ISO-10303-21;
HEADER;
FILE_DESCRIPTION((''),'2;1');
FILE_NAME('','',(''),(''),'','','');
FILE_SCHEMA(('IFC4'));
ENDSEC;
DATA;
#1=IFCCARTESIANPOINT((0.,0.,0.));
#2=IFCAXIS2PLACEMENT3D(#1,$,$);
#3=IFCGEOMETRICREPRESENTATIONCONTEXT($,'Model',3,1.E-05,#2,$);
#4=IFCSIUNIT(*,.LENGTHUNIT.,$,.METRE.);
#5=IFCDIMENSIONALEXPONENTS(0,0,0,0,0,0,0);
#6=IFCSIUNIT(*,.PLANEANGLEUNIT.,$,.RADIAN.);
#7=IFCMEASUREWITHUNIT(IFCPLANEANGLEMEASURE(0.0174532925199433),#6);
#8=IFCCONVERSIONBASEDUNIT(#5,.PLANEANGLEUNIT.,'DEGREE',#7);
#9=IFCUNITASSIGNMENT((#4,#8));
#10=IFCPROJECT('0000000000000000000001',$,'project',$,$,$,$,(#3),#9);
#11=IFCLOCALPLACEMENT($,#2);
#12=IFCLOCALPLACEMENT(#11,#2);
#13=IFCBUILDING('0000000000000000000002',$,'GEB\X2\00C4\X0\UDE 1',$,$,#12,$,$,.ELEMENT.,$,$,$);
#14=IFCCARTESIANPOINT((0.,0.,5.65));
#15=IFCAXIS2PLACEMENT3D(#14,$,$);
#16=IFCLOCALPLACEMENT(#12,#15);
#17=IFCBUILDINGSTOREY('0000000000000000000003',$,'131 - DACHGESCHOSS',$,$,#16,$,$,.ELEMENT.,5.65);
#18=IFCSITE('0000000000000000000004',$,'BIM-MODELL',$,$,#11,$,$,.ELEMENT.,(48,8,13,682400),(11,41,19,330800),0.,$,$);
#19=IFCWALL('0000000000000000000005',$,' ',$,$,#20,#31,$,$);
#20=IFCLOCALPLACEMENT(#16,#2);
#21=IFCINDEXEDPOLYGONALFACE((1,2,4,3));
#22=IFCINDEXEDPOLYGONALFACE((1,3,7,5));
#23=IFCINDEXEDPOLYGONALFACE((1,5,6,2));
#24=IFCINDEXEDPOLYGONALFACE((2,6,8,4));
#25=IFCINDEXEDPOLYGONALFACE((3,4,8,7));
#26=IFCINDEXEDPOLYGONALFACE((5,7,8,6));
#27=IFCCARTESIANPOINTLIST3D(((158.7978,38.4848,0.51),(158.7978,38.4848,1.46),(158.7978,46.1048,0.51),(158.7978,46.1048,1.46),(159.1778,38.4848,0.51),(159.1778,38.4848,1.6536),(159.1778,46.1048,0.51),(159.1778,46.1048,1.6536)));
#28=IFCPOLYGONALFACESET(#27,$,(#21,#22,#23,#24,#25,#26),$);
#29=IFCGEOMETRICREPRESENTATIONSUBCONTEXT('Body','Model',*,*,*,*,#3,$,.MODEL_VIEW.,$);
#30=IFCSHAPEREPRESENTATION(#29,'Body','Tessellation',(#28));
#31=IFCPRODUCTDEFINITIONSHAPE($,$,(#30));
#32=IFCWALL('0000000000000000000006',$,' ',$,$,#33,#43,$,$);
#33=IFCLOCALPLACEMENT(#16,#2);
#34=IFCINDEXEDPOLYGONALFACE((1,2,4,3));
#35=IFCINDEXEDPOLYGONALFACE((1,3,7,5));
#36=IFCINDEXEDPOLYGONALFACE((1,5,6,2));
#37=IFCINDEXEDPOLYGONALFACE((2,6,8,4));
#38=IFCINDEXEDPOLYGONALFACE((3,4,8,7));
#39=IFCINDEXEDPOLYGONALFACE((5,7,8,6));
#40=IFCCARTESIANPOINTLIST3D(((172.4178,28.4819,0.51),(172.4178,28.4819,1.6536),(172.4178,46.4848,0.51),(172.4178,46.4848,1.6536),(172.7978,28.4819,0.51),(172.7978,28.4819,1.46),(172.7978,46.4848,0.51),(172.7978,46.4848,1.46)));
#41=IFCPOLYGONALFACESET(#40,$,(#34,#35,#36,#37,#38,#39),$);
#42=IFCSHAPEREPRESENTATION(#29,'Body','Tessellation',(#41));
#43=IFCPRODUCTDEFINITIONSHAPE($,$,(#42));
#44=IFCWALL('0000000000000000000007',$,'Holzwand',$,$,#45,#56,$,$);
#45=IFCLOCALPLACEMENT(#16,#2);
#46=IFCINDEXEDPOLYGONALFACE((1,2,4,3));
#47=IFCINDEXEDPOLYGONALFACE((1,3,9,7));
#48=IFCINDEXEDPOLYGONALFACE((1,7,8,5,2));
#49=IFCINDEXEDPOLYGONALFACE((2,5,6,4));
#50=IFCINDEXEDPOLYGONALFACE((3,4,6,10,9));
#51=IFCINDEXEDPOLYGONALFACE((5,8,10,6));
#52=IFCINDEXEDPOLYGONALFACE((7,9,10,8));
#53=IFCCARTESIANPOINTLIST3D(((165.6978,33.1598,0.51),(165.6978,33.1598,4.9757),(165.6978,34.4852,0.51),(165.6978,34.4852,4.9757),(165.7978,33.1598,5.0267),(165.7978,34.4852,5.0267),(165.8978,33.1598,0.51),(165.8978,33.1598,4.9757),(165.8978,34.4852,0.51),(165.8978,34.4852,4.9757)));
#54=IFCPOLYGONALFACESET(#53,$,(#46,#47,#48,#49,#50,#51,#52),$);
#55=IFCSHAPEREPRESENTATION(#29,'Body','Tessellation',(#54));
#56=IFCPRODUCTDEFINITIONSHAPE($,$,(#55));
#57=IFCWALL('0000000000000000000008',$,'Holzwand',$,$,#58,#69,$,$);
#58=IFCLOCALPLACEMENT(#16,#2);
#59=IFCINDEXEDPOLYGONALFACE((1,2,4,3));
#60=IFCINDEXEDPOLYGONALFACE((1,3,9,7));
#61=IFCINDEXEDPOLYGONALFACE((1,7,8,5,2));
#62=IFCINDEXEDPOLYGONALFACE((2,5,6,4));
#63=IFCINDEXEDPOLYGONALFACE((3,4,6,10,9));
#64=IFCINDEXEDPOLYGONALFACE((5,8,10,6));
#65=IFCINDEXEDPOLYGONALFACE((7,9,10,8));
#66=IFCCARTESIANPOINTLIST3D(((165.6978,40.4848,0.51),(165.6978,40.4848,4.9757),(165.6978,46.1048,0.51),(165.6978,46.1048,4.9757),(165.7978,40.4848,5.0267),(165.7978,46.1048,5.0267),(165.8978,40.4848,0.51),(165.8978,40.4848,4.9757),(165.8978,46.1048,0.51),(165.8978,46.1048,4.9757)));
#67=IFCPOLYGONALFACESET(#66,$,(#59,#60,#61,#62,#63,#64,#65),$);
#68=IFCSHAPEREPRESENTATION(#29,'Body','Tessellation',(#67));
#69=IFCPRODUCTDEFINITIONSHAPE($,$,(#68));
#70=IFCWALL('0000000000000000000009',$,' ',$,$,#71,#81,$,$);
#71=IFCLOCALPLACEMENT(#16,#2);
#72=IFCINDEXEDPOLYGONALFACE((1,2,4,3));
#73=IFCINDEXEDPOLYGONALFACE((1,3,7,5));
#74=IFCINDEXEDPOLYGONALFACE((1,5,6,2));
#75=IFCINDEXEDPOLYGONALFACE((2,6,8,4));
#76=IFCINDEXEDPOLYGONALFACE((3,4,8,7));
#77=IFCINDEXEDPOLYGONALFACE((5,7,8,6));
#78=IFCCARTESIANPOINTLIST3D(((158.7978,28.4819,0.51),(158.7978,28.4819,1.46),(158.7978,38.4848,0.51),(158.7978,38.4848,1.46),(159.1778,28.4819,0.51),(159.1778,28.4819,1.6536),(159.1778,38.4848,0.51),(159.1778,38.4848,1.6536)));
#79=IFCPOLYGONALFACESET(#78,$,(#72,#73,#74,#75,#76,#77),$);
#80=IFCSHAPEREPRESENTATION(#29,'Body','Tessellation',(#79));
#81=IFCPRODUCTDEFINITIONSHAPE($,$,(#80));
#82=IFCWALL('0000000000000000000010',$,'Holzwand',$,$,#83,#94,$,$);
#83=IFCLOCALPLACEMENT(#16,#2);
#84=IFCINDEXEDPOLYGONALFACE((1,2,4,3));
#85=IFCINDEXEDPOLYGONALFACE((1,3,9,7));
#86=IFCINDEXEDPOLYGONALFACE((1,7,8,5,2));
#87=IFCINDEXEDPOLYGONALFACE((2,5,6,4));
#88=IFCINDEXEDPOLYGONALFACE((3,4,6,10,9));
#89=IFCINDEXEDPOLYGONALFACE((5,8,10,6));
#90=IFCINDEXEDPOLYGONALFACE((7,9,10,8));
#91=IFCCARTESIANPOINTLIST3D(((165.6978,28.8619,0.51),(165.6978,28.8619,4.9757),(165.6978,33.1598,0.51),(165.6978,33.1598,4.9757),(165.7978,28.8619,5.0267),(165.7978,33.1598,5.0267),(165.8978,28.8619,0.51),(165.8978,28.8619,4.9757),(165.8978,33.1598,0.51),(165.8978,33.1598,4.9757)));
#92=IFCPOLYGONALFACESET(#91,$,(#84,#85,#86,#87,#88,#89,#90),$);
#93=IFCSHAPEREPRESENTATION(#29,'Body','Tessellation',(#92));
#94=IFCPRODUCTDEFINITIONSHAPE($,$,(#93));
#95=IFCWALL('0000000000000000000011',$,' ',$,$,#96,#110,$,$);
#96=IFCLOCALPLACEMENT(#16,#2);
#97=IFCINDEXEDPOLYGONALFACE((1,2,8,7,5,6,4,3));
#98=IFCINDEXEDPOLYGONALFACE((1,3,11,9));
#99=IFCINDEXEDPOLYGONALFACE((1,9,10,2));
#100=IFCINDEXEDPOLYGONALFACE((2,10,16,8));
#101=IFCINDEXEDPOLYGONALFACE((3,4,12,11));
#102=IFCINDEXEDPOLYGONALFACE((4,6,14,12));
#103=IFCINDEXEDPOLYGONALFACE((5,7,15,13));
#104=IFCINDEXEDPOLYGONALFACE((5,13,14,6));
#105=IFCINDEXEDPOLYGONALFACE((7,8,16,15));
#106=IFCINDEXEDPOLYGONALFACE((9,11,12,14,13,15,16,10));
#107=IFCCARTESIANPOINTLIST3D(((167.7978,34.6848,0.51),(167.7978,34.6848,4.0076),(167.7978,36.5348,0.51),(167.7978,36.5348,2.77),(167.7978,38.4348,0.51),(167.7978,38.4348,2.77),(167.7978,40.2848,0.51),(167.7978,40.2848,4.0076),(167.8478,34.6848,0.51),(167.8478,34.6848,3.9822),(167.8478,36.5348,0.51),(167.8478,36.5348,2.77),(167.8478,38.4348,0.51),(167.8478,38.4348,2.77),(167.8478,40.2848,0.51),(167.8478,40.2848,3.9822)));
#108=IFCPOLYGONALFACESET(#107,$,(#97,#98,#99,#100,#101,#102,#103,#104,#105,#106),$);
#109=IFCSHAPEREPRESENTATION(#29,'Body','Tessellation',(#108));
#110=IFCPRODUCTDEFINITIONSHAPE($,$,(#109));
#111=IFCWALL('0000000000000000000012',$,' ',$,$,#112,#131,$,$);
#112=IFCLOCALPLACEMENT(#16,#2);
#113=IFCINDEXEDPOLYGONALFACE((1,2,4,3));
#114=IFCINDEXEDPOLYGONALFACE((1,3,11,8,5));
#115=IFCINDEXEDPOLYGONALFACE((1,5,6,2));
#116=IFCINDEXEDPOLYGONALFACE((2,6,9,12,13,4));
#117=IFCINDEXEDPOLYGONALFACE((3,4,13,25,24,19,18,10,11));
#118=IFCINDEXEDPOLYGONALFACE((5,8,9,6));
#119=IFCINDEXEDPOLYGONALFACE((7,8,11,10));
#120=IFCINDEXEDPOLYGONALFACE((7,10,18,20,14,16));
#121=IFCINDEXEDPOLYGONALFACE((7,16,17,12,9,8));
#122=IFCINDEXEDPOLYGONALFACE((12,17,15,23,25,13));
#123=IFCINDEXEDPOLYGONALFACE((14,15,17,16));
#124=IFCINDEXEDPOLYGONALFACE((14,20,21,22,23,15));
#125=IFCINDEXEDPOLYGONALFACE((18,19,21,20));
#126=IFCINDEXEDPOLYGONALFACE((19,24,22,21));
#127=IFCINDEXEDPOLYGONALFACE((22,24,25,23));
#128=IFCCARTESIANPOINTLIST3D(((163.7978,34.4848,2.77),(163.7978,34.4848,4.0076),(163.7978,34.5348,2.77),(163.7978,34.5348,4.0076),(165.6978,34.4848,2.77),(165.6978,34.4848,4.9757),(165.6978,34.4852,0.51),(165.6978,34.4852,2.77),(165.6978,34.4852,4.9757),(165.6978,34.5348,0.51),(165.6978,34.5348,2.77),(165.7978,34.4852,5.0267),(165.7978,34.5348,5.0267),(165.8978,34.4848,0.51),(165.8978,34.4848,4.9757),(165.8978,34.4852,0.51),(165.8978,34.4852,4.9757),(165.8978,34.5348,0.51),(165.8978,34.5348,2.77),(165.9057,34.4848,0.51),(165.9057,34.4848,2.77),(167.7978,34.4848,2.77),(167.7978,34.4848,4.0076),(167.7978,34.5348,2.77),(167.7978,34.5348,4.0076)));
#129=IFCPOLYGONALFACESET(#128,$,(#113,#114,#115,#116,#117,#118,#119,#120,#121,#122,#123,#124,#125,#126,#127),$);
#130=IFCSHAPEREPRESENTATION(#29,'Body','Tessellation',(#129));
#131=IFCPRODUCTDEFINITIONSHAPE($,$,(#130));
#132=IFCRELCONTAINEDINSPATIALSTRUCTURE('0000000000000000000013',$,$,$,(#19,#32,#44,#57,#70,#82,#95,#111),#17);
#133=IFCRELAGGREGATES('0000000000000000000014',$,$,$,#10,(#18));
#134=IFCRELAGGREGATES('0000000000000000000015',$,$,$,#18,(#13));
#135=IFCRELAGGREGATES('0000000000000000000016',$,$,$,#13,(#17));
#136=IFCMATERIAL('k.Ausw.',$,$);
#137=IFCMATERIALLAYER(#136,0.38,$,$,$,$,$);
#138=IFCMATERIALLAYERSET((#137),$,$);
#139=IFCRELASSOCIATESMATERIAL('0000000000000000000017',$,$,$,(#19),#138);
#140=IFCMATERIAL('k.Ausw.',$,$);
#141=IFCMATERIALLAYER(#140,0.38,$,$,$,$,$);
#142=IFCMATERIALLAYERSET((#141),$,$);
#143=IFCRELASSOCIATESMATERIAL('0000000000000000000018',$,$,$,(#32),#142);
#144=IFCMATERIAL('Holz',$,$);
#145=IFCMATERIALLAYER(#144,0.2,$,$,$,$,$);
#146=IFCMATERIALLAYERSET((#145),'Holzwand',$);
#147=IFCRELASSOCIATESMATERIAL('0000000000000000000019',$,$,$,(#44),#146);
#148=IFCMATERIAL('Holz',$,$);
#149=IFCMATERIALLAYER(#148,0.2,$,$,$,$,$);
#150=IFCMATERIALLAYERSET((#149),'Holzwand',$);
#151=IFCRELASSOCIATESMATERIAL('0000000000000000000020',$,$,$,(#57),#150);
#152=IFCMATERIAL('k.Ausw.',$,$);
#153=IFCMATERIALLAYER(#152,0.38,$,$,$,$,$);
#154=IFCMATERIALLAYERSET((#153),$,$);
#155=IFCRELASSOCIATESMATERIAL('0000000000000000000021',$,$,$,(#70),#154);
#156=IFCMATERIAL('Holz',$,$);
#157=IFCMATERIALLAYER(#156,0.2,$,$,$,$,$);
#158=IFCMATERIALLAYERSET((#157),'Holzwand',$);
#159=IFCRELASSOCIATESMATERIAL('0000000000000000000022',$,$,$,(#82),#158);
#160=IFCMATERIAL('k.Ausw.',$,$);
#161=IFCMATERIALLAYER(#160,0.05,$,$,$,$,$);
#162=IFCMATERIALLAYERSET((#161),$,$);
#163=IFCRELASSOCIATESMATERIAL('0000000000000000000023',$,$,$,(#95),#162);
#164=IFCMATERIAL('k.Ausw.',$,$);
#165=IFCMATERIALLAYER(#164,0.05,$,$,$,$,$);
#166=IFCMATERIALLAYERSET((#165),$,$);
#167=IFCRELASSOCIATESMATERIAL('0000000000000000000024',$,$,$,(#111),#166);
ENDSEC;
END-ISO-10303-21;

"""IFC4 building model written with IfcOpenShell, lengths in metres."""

from ifc_helpers import new_model, entity, si_unit, converted_unit, frame, frame_2d, origin, origin_with_axes, place, context, subcontext, project, spatial, polyline, rectangle, outline, extrude, clip, halfspace, bounded_halfspace, material, layer, layer_set, layer_usage, element, save


model = new_model("IFC4")

# Units and contexts
model_context = context("Model", 3, precision=1e-05, world=origin())
body_context = subcontext(model_context, "Body", "Model", "MODEL_VIEW")
ifc_project = project(units=[si_unit("LENGTHUNIT", "METRE"), converted_unit("PLANEANGLEUNIT", "DEGREE", entity("IfcPlaneAngleMeasure", 0.0174532925199433), si_unit("PLANEANGLEUNIT", "RADIAN"), dimensions=[0, 0, 0, 0, 0, 0, 0])], contexts=[model_context])

# Site, building, storey
site_placement = place(None, origin())
site = spatial("IfcSite", under=ifc_project, at=site_placement, Name="BIM-MODELL", CompositionType="ELEMENT", RefLatitude=(48, 8, 13, 682400), RefLongitude=(11, 41, 19, 330800), RefElevation=0.0)
building_placement = place(site_placement, origin())
building = spatial("IfcBuilding", under=site, at=building_placement, Name="GEBÄUDE 1", CompositionType="ELEMENT")
storey_placement = place(building_placement, frame((0.0, 0.0, 5.65)))
storey = spatial("IfcBuildingStorey", under=building, at=storey_placement, Name="131 - DACHGESCHOSS", CompositionType="ELEMENT", Elevation=5.65)

# Walls
ifc_material_1 = material(Name="k.Ausw.")
ifc_layer_1 = layer(ifc_material_1, 0.38)
ifc_layer_set_1 = layer_set([ifc_layer_1])
ifc_layer_usage_1 = layer_usage(ifc_layer_set_1, "AXIS2", "POSITIVE", 0.0)
wall_1_placement = place(storey_placement, frame((158.7978, 46.1048, 0.51), z_axis=(0.0, 0.0, 1.0), x_axis=(0.0, -1.0, 0.0)))
element("IfcWall", 1, at=wall_1_placement, inside=storey, material=ifc_layer_usage_1, Name=" ", context=body_context, shape_type="Clipping", body=[
    clip(extrude(rectangle(XDim=7.62, YDim=0.38, at=frame_2d((3.81, 0.19), x_axis=(1.0, 0.0))), origin_with_axes(), (0.0, 0.0, 1.0), 1.1436), halfspace(frame((3.81, 0.19, 1.0468), z_axis=(0.0, 0.45399, -0.891007), x_axis=(0.0, -0.891007, -0.45399)), True)),
])
ifc_material_2 = material(Name="k.Ausw.")
ifc_layer_2 = layer(ifc_material_2, 0.38)
ifc_layer_set_2 = layer_set([ifc_layer_2])
ifc_layer_usage_2 = layer_usage(ifc_layer_set_2, "AXIS2", "POSITIVE", 0.0)
wall_2_placement = place(storey_placement, frame((172.7978, 28.4819, 0.51), z_axis=(0.0, 0.0, 1.0), x_axis=(0.0, 1.0, 0.0)))
element("IfcWall", 2, at=wall_2_placement, inside=storey, material=ifc_layer_usage_2, Name=" ", context=body_context, shape_type="Clipping", body=[
    clip(extrude(rectangle(XDim=18.0029, YDim=0.38, at=frame_2d((9.0014, 0.19), x_axis=(1.0, 0.0))), origin_with_axes(), (0.0, 0.0, 1.0), 1.1436), halfspace(frame((9.0014, 0.19, 1.0468), z_axis=(0.0, 0.45399, -0.891007), x_axis=(0.0, -0.891007, -0.45399)), True)),
])
ifc_material_3 = material(Name="Holz")
ifc_layer_3 = layer(ifc_material_3, 0.2)
ifc_layer_set_3 = layer_set([ifc_layer_3], Name="Holzwand")
ifc_layer_usage_3 = layer_usage(ifc_layer_set_3, "AXIS2", "POSITIVE", 0.0)
wall_3_placement = place(storey_placement, frame((165.6978, 34.4852, 0.51), z_axis=(0.0, 0.0, 1.0), x_axis=(0.0, -1.0, 0.0)))
element("IfcWall", 3, at=wall_3_placement, inside=storey, material=ifc_layer_usage_3, Name="Holzwand", context=body_context, shape_type="Clipping", body=[
    clip(clip(extrude(rectangle(XDim=1.3254, YDim=0.2, at=frame_2d((0.6627, 0.1), x_axis=(1.0, 0.0))), origin_with_axes(), (0.0, 0.0, 1.0), 4.5167), bounded_halfspace(frame((0.6627, 0.15, 4.4912), z_axis=(0.0, -0.45399, -0.891007), x_axis=(0.0, -0.891007, 0.45399)), True, origin_with_axes(), polyline([(0.0, 0.2), (0.0, 0.1), (1.3254, 0.1), (1.3254, 0.2), (0.0, 0.2)]))), bounded_halfspace(frame((0.6627, 0.05, 4.4912), z_axis=(0.0, 0.45399, -0.891007), x_axis=(1.0, 0.0, 0.0)), True, origin_with_axes(), polyline([(0.0, 0.0), (1.3254, 0.0), (1.3254, 0.1), (0.0, 0.1), (0.0, 0.0)]))),
])
ifc_material_4 = material(Name="Holz")
ifc_layer_4 = layer(ifc_material_4, 0.2)
ifc_layer_set_4 = layer_set([ifc_layer_4], Name="Holzwand")
ifc_layer_usage_4 = layer_usage(ifc_layer_set_4, "AXIS2", "POSITIVE", 0.0)
wall_4_placement = place(storey_placement, frame((165.6978, 46.1048, 0.51), z_axis=(0.0, 0.0, 1.0), x_axis=(0.0, -1.0, 0.0)))
element("IfcWall", 4, at=wall_4_placement, inside=storey, material=ifc_layer_usage_4, Name="Holzwand", context=body_context, shape_type="Clipping", body=[
    clip(clip(extrude(rectangle(XDim=5.62, YDim=0.2, at=frame_2d((2.81, 0.1), x_axis=(1.0, 0.0))), origin_with_axes(), (0.0, 0.0, 1.0), 4.5167), bounded_halfspace(frame((2.81, 0.15, 4.4912), z_axis=(0.0, -0.45399, -0.891007), x_axis=(0.0, -0.891007, 0.45399)), True, origin_with_axes(), polyline([(0.0, 0.2), (0.0, 0.1), (5.62, 0.1), (5.62, 0.2), (0.0, 0.2)]))), bounded_halfspace(frame((2.81, 0.05, 4.4912), z_axis=(0.0, 0.45399, -0.891007), x_axis=(1.0, 0.0, 0.0)), True, origin_with_axes(), polyline([(0.0, 0.0), (5.62, 0.0), (5.62, 0.1), (0.0, 0.1), (0.0, 0.0)]))),
])
ifc_material_5 = material(Name="k.Ausw.")
ifc_layer_5 = layer(ifc_material_5, 0.38)
ifc_layer_set_5 = layer_set([ifc_layer_5])
ifc_layer_usage_5 = layer_usage(ifc_layer_set_5, "AXIS2", "POSITIVE", 0.0)
wall_5_placement = place(storey_placement, frame((158.7978, 38.4848, 0.51), z_axis=(0.0, 0.0, 1.0), x_axis=(0.0, -1.0, 0.0)))
element("IfcWall", 5, at=wall_5_placement, inside=storey, material=ifc_layer_usage_5, Name=" ", context=body_context, shape_type="Clipping", body=[
    clip(extrude(rectangle(XDim=10.0029, YDim=0.38, at=frame_2d((5.0014, 0.19), x_axis=(1.0, 0.0))), origin_with_axes(), (0.0, 0.0, 1.0), 1.1436), halfspace(frame((5.0014, 0.19, 1.0468), z_axis=(0.0, 0.45399, -0.891007), x_axis=(0.0, -0.891007, -0.45399)), True)),
])
ifc_material_6 = material(Name="Holz")
ifc_layer_6 = layer(ifc_material_6, 0.2)
ifc_layer_set_6 = layer_set([ifc_layer_6], Name="Holzwand")
ifc_layer_usage_6 = layer_usage(ifc_layer_set_6, "AXIS2", "POSITIVE", 0.0)
wall_6_placement = place(storey_placement, frame((165.6978, 33.1598, 0.51), z_axis=(0.0, 0.0, 1.0), x_axis=(0.0, -1.0, 0.0)))
element("IfcWall", 6, at=wall_6_placement, inside=storey, material=ifc_layer_usage_6, Name="Holzwand", context=body_context, shape_type="Clipping", body=[
    clip(clip(extrude(rectangle(XDim=4.2979, YDim=0.2, at=frame_2d((2.1489, 0.1), x_axis=(1.0, 0.0))), origin_with_axes(), (0.0, 0.0, 1.0), 4.5167), bounded_halfspace(frame((2.1489, 0.15, 4.4912), z_axis=(0.0, -0.45399, -0.891007), x_axis=(0.0, -0.891007, 0.45399)), True, origin_with_axes(), polyline([(0.0, 0.2), (0.0, 0.1), (4.2979, 0.1), (4.2979, 0.2), (0.0, 0.2)]))), bounded_halfspace(frame((2.1489, 0.05, 4.4912), z_axis=(0.0, 0.45399, -0.891007), x_axis=(1.0, 0.0, 0.0)), True, origin_with_axes(), polyline([(0.0, 0.0), (4.2979, 0.0), (4.2979, 0.1), (0.0, 0.1), (0.0, 0.0)]))),
])

# Wall, opening
ifc_material_7 = material(Name="k.Ausw.")
ifc_layer_7 = layer(ifc_material_7, 0.05)
ifc_layer_set_7 = layer_set([ifc_layer_7])
ifc_layer_usage_7 = layer_usage(ifc_layer_set_7, "AXIS2", "POSITIVE", 0.0)
wall_7_placement = place(storey_placement, frame((167.8478, 34.6848, 0.51), z_axis=(0.0, 0.0, 1.0), x_axis=(0.0, 1.0, 0.0)))
wall_7 = element("IfcWall", 7, at=wall_7_placement, inside=storey, material=ifc_layer_usage_7, Name=" ", context=body_context, shape_type="Clipping", body=[
    clip(extrude(rectangle(XDim=5.6, YDim=0.05, at=frame_2d((2.8, 0.025), x_axis=(1.0, 0.0))), origin_with_axes(), (0.0, 0.0, 1.0), 3.4976), halfspace(frame((2.8, 0.025, 3.4849), z_axis=(0.0, 0.45399, -0.891007), x_axis=(1.0, 0.0, 0.0)), True)),
])
opening_1_placement = place(wall_7_placement, frame((1.85, 0.0, 0.0), z_axis=(0.0, 1.0, 0.0), x_axis=(0.0, 0.0, 1.0)))
element("IfcOpeningElement", 8, at=opening_1_placement, cuts=wall_7, ObjectType="Opening", context=body_context, shape_type="SweptSolid", body=[
    extrude(outline(polyline([(0.0, 1.9), (2.26, 1.9), (2.26, 0.0), (0.0, 0.0), (0.0, 1.9)])), origin_with_axes(), (0.0, 0.0, 1.0), 0.05),
])

# Wall, openings
ifc_material_8 = material(Name="k.Ausw.")
ifc_layer_8 = layer(ifc_material_8, 0.05)
ifc_layer_set_8 = layer_set([ifc_layer_8])
ifc_layer_usage_8 = layer_usage(ifc_layer_set_8, "AXIS2", "POSITIVE", 0.0)
wall_8_placement = place(storey_placement, frame((163.7978, 34.4848, 0.51), z_axis=(0.0, 0.0, 1.0), x_axis=(1.0, 0.0, 0.0)))
wall_8 = element("IfcWall", 9, at=wall_8_placement, inside=storey, material=ifc_layer_usage_8, Name=" ", context=body_context, shape_type="Clipping", body=[
    clip(clip(extrude(outline(polyline([(0.0, 0.0), (1.9, 0.0), (1.9, 0.0004), (2.1, 0.0004), (2.1, 0.0), (4.0, 0.0), (4.0, 0.05), (0.0, 0.05), (0.0, 0.0)])), origin_with_axes(), (0.0, 0.0, 1.0), 4.5167), bounded_halfspace(frame((2.7, 0.0168, 4.16), z_axis=(-0.45399, 0.0, -0.891007), x_axis=(-0.891007, 0.0, 0.45399)), True, origin_with_axes(), polyline([(4.0, 0.05), (2.0, 0.05), (2.0, 0.0004), (2.1, 0.0004), (2.1, 0.0), (4.0, 0.0), (4.0, 0.05)]))), bounded_halfspace(frame((1.3, 0.0168, 4.16), z_axis=(0.45399, 0.0, -0.891007), x_axis=(0.891007, 0.0, 0.45399)), True, origin_with_axes(), polyline([(0.0, 0.0), (1.9, 0.0), (1.9, 0.0004), (2.0, 0.0004), (2.0, 0.05), (0.0, 0.05), (0.0, 0.0)]))),
])
opening_2_placement = place(wall_8_placement, frame((0.0, 0.0, 0.0), z_axis=(0.0, 1.0, 0.0), x_axis=(0.0, 0.0, 1.0)))
element("IfcOpeningElement", 10, at=opening_2_placement, cuts=wall_8, ObjectType="Opening", context=body_context, shape_type="SweptSolid", body=[
    extrude(outline(polyline([(0.0, 1.9), (2.26, 1.9), (2.26, 0.0), (0.0, 0.0), (0.0, 1.9)])), origin_with_axes(), (0.0, 0.0, 1.0), 0.05),
])
opening_3_placement = place(wall_8_placement, frame((2.108, 0.0, 0.0), z_axis=(0.0, 0.0, 1.0), x_axis=(1.0, 0.0, 0.0)))
element("IfcOpeningElement", 11, at=opening_3_placement, cuts=wall_8, ObjectType="Opening", context=body_context, shape_type="SweptSolid", body=[
    extrude(outline(polyline([(0.0, 0.0), (1.892, 0.0), (1.892, 0.05), (-0.008, 0.05), (0.0, 0.0)])), origin_with_axes(), (0.0, 0.0, 1.0), 2.26),
])

save(model, "model.ifc")
